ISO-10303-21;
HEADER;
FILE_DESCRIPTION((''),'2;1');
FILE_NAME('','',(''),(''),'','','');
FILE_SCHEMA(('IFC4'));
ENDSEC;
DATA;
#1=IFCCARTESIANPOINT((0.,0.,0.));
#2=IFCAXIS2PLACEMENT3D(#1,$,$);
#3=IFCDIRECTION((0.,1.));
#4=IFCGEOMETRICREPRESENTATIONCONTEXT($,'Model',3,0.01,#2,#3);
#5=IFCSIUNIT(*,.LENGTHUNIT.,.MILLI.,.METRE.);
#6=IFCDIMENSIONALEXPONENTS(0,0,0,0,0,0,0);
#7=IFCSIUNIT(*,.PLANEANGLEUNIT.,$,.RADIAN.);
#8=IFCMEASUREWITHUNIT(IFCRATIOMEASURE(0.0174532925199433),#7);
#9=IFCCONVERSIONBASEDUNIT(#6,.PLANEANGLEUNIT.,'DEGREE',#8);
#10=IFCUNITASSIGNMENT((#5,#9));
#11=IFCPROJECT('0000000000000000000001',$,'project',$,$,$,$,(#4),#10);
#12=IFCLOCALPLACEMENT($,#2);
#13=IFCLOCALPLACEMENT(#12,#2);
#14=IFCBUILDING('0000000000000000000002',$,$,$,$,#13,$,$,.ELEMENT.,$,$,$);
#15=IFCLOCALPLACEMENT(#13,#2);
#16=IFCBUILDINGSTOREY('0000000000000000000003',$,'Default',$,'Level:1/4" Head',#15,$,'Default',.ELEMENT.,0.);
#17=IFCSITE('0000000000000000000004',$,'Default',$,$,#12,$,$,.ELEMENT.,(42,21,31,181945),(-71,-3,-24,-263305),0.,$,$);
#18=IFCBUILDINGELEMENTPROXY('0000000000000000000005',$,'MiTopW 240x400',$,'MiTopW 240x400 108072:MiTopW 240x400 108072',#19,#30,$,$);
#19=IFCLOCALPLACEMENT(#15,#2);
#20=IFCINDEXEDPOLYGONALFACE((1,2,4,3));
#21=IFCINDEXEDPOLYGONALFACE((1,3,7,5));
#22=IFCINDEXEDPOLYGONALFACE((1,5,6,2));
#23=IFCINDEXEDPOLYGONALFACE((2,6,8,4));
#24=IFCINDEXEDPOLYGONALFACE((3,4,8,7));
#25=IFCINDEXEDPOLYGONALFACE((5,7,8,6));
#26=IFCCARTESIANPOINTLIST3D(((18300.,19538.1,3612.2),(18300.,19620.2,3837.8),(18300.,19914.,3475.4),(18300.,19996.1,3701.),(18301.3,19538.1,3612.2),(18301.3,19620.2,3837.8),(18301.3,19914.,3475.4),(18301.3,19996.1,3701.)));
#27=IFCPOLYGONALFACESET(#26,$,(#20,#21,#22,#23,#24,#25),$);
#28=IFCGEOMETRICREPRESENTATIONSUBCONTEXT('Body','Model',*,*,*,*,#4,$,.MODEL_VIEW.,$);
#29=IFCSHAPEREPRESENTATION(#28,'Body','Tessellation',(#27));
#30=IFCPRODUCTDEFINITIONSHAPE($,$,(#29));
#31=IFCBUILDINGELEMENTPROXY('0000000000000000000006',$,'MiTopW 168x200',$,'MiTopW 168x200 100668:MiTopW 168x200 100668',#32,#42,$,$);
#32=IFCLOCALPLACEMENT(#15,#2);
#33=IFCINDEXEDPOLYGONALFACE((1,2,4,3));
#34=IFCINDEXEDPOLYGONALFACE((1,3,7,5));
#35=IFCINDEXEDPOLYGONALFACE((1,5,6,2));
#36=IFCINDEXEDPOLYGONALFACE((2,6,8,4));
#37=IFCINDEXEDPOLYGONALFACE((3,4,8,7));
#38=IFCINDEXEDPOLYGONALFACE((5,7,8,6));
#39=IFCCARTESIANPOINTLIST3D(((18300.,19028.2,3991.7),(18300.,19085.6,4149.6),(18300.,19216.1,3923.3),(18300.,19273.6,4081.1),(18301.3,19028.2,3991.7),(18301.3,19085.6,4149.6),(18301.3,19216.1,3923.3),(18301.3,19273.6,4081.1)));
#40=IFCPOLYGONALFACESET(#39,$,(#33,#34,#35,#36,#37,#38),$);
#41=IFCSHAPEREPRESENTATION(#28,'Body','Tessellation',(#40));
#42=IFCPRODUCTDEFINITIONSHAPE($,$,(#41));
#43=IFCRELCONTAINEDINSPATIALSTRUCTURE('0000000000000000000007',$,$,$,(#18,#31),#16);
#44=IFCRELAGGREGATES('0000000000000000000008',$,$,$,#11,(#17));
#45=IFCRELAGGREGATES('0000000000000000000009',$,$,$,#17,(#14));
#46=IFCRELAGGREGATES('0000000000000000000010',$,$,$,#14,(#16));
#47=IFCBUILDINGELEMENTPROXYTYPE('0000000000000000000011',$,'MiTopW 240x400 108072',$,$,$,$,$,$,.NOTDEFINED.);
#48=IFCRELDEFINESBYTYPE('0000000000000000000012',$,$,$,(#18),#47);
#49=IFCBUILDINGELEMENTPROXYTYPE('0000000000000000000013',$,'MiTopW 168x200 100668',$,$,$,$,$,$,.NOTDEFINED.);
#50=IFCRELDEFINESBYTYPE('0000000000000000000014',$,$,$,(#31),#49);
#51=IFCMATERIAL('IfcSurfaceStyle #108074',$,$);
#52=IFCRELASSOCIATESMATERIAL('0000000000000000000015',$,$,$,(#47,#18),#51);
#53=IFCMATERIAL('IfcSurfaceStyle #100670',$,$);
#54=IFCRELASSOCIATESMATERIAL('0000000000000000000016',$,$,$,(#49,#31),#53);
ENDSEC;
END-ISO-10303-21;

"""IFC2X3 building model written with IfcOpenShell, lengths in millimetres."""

from ifc_helpers import new_model, entity, si_unit, converted_unit, direction, frame, origin, place, context, subcontext, project, spatial, polyline, outline, extrude, source, transform, mapped, material, type_object, type_shapes, element, save


model = new_model("IFC2X3")

# Units and contexts
model_context = context("Model", 3, precision=0.01, world=origin(), true_north=direction((0.0, 1.0)))
body_context = subcontext(model_context, "Body", "Model", "MODEL_VIEW")
ifc_project = project(units=[si_unit("LENGTHUNIT", "METRE", prefix="MILLI"), converted_unit("PLANEANGLEUNIT", "DEGREE", entity("IfcRatioMeasure", 0.0174532925199433), si_unit("PLANEANGLEUNIT", "RADIAN"), dimensions=[0, 0, 0, 0, 0, 0, 0])], contexts=[model_context])

# Site, building, storey
site_placement = place(None, origin())
site = spatial("IfcSite", under=ifc_project, at=site_placement, Name="Default", CompositionType="ELEMENT", RefLatitude=(42, 21, 31, 181945), RefLongitude=(-71, -3, -24, -263305), RefElevation=0.0)
building_placement = place(site_placement, origin())
building = spatial("IfcBuilding", under=site, at=building_placement, CompositionType="ELEMENT")
storey_placement = place(building_placement, origin())
storey = spatial("IfcBuildingStorey", under=building, at=storey_placement, Name="Default", ObjectType="Level:1/4\" Head", LongName="Default", CompositionType="ELEMENT", Elevation=0.0)

# Building element proxies
ifc_material_1 = material(Name="IfcSurfaceStyle #108074")
building_element_proxy_type_1 = type_object("IfcBuildingElementProxyType", Name="MiTopW 240x400 108072", PredefinedType="NOTDEFINED", material=ifc_material_1)
shared_shape_1 = source(origin(), body_context, "Body", "SweptSolid", [
    extrude(outline(polyline([(-200.0, -120.0), (200.0, -120.0), (200.0, 120.0), (-200.0, 120.0), (-200.0, -120.0)])), frame((200.0, 120.0, 0.0), z_axis=(0.0, 0.0, 1.0), x_axis=(-1.0, 0.0, 0.0)), (0.0, 0.0, 1.0), 1.3),
])
type_shapes(building_element_proxy_type_1, [shared_shape_1])
proxy_1_placement = place(building_placement, frame((18301.3, 19620.2, 3837.8), z_axis=(-1.0, 0.0, 0.0), x_axis=(0.0, 0.939693, -0.34202)))
element("IfcBuildingElementProxy", 1, at=proxy_1_placement, inside=storey, type_object=building_element_proxy_type_1, material=ifc_material_1, Name="MiTopW 240x400", ObjectType="MiTopW 240x400 108072:MiTopW 240x400 108072", context=body_context, shape_type="MappedRepresentation", body=[
    mapped(shared_shape_1, transform((0.0, 0.0, 0.0), scale=1.0)),
])
ifc_material_2 = material(Name="IfcSurfaceStyle #100670")
building_element_proxy_type_2 = type_object("IfcBuildingElementProxyType", Name="MiTopW 168x200 100668", PredefinedType="NOTDEFINED", material=ifc_material_2)
shared_shape_2 = source(origin(), body_context, "Body", "SweptSolid", [
    extrude(outline(polyline([(-100.0, -84.0), (100.0, -84.0), (100.0, 84.0), (-100.0, 84.0), (-100.0, -84.0)])), frame((100.0, 84.0, 0.0), z_axis=(0.0, 0.0, 1.0), x_axis=(-1.0, 0.0, 0.0)), (0.0, 0.0, 1.0), 1.3),
])
type_shapes(building_element_proxy_type_2, [shared_shape_2])
proxy_2_placement = place(building_placement, frame((18301.3, 19216.1, 3923.3), z_axis=(-1.0, 0.0, 0.0), x_axis=(0.0, -0.939693, 0.34202)))
element("IfcBuildingElementProxy", 2, at=proxy_2_placement, inside=storey, type_object=building_element_proxy_type_2, material=ifc_material_2, Name="MiTopW 168x200", ObjectType="MiTopW 168x200 100668:MiTopW 168x200 100668", context=body_context, shape_type="MappedRepresentation", body=[
    mapped(shared_shape_2, transform((0.0, 0.0, 0.0), scale=1.0)),
])

save(model, "model.ifc")
